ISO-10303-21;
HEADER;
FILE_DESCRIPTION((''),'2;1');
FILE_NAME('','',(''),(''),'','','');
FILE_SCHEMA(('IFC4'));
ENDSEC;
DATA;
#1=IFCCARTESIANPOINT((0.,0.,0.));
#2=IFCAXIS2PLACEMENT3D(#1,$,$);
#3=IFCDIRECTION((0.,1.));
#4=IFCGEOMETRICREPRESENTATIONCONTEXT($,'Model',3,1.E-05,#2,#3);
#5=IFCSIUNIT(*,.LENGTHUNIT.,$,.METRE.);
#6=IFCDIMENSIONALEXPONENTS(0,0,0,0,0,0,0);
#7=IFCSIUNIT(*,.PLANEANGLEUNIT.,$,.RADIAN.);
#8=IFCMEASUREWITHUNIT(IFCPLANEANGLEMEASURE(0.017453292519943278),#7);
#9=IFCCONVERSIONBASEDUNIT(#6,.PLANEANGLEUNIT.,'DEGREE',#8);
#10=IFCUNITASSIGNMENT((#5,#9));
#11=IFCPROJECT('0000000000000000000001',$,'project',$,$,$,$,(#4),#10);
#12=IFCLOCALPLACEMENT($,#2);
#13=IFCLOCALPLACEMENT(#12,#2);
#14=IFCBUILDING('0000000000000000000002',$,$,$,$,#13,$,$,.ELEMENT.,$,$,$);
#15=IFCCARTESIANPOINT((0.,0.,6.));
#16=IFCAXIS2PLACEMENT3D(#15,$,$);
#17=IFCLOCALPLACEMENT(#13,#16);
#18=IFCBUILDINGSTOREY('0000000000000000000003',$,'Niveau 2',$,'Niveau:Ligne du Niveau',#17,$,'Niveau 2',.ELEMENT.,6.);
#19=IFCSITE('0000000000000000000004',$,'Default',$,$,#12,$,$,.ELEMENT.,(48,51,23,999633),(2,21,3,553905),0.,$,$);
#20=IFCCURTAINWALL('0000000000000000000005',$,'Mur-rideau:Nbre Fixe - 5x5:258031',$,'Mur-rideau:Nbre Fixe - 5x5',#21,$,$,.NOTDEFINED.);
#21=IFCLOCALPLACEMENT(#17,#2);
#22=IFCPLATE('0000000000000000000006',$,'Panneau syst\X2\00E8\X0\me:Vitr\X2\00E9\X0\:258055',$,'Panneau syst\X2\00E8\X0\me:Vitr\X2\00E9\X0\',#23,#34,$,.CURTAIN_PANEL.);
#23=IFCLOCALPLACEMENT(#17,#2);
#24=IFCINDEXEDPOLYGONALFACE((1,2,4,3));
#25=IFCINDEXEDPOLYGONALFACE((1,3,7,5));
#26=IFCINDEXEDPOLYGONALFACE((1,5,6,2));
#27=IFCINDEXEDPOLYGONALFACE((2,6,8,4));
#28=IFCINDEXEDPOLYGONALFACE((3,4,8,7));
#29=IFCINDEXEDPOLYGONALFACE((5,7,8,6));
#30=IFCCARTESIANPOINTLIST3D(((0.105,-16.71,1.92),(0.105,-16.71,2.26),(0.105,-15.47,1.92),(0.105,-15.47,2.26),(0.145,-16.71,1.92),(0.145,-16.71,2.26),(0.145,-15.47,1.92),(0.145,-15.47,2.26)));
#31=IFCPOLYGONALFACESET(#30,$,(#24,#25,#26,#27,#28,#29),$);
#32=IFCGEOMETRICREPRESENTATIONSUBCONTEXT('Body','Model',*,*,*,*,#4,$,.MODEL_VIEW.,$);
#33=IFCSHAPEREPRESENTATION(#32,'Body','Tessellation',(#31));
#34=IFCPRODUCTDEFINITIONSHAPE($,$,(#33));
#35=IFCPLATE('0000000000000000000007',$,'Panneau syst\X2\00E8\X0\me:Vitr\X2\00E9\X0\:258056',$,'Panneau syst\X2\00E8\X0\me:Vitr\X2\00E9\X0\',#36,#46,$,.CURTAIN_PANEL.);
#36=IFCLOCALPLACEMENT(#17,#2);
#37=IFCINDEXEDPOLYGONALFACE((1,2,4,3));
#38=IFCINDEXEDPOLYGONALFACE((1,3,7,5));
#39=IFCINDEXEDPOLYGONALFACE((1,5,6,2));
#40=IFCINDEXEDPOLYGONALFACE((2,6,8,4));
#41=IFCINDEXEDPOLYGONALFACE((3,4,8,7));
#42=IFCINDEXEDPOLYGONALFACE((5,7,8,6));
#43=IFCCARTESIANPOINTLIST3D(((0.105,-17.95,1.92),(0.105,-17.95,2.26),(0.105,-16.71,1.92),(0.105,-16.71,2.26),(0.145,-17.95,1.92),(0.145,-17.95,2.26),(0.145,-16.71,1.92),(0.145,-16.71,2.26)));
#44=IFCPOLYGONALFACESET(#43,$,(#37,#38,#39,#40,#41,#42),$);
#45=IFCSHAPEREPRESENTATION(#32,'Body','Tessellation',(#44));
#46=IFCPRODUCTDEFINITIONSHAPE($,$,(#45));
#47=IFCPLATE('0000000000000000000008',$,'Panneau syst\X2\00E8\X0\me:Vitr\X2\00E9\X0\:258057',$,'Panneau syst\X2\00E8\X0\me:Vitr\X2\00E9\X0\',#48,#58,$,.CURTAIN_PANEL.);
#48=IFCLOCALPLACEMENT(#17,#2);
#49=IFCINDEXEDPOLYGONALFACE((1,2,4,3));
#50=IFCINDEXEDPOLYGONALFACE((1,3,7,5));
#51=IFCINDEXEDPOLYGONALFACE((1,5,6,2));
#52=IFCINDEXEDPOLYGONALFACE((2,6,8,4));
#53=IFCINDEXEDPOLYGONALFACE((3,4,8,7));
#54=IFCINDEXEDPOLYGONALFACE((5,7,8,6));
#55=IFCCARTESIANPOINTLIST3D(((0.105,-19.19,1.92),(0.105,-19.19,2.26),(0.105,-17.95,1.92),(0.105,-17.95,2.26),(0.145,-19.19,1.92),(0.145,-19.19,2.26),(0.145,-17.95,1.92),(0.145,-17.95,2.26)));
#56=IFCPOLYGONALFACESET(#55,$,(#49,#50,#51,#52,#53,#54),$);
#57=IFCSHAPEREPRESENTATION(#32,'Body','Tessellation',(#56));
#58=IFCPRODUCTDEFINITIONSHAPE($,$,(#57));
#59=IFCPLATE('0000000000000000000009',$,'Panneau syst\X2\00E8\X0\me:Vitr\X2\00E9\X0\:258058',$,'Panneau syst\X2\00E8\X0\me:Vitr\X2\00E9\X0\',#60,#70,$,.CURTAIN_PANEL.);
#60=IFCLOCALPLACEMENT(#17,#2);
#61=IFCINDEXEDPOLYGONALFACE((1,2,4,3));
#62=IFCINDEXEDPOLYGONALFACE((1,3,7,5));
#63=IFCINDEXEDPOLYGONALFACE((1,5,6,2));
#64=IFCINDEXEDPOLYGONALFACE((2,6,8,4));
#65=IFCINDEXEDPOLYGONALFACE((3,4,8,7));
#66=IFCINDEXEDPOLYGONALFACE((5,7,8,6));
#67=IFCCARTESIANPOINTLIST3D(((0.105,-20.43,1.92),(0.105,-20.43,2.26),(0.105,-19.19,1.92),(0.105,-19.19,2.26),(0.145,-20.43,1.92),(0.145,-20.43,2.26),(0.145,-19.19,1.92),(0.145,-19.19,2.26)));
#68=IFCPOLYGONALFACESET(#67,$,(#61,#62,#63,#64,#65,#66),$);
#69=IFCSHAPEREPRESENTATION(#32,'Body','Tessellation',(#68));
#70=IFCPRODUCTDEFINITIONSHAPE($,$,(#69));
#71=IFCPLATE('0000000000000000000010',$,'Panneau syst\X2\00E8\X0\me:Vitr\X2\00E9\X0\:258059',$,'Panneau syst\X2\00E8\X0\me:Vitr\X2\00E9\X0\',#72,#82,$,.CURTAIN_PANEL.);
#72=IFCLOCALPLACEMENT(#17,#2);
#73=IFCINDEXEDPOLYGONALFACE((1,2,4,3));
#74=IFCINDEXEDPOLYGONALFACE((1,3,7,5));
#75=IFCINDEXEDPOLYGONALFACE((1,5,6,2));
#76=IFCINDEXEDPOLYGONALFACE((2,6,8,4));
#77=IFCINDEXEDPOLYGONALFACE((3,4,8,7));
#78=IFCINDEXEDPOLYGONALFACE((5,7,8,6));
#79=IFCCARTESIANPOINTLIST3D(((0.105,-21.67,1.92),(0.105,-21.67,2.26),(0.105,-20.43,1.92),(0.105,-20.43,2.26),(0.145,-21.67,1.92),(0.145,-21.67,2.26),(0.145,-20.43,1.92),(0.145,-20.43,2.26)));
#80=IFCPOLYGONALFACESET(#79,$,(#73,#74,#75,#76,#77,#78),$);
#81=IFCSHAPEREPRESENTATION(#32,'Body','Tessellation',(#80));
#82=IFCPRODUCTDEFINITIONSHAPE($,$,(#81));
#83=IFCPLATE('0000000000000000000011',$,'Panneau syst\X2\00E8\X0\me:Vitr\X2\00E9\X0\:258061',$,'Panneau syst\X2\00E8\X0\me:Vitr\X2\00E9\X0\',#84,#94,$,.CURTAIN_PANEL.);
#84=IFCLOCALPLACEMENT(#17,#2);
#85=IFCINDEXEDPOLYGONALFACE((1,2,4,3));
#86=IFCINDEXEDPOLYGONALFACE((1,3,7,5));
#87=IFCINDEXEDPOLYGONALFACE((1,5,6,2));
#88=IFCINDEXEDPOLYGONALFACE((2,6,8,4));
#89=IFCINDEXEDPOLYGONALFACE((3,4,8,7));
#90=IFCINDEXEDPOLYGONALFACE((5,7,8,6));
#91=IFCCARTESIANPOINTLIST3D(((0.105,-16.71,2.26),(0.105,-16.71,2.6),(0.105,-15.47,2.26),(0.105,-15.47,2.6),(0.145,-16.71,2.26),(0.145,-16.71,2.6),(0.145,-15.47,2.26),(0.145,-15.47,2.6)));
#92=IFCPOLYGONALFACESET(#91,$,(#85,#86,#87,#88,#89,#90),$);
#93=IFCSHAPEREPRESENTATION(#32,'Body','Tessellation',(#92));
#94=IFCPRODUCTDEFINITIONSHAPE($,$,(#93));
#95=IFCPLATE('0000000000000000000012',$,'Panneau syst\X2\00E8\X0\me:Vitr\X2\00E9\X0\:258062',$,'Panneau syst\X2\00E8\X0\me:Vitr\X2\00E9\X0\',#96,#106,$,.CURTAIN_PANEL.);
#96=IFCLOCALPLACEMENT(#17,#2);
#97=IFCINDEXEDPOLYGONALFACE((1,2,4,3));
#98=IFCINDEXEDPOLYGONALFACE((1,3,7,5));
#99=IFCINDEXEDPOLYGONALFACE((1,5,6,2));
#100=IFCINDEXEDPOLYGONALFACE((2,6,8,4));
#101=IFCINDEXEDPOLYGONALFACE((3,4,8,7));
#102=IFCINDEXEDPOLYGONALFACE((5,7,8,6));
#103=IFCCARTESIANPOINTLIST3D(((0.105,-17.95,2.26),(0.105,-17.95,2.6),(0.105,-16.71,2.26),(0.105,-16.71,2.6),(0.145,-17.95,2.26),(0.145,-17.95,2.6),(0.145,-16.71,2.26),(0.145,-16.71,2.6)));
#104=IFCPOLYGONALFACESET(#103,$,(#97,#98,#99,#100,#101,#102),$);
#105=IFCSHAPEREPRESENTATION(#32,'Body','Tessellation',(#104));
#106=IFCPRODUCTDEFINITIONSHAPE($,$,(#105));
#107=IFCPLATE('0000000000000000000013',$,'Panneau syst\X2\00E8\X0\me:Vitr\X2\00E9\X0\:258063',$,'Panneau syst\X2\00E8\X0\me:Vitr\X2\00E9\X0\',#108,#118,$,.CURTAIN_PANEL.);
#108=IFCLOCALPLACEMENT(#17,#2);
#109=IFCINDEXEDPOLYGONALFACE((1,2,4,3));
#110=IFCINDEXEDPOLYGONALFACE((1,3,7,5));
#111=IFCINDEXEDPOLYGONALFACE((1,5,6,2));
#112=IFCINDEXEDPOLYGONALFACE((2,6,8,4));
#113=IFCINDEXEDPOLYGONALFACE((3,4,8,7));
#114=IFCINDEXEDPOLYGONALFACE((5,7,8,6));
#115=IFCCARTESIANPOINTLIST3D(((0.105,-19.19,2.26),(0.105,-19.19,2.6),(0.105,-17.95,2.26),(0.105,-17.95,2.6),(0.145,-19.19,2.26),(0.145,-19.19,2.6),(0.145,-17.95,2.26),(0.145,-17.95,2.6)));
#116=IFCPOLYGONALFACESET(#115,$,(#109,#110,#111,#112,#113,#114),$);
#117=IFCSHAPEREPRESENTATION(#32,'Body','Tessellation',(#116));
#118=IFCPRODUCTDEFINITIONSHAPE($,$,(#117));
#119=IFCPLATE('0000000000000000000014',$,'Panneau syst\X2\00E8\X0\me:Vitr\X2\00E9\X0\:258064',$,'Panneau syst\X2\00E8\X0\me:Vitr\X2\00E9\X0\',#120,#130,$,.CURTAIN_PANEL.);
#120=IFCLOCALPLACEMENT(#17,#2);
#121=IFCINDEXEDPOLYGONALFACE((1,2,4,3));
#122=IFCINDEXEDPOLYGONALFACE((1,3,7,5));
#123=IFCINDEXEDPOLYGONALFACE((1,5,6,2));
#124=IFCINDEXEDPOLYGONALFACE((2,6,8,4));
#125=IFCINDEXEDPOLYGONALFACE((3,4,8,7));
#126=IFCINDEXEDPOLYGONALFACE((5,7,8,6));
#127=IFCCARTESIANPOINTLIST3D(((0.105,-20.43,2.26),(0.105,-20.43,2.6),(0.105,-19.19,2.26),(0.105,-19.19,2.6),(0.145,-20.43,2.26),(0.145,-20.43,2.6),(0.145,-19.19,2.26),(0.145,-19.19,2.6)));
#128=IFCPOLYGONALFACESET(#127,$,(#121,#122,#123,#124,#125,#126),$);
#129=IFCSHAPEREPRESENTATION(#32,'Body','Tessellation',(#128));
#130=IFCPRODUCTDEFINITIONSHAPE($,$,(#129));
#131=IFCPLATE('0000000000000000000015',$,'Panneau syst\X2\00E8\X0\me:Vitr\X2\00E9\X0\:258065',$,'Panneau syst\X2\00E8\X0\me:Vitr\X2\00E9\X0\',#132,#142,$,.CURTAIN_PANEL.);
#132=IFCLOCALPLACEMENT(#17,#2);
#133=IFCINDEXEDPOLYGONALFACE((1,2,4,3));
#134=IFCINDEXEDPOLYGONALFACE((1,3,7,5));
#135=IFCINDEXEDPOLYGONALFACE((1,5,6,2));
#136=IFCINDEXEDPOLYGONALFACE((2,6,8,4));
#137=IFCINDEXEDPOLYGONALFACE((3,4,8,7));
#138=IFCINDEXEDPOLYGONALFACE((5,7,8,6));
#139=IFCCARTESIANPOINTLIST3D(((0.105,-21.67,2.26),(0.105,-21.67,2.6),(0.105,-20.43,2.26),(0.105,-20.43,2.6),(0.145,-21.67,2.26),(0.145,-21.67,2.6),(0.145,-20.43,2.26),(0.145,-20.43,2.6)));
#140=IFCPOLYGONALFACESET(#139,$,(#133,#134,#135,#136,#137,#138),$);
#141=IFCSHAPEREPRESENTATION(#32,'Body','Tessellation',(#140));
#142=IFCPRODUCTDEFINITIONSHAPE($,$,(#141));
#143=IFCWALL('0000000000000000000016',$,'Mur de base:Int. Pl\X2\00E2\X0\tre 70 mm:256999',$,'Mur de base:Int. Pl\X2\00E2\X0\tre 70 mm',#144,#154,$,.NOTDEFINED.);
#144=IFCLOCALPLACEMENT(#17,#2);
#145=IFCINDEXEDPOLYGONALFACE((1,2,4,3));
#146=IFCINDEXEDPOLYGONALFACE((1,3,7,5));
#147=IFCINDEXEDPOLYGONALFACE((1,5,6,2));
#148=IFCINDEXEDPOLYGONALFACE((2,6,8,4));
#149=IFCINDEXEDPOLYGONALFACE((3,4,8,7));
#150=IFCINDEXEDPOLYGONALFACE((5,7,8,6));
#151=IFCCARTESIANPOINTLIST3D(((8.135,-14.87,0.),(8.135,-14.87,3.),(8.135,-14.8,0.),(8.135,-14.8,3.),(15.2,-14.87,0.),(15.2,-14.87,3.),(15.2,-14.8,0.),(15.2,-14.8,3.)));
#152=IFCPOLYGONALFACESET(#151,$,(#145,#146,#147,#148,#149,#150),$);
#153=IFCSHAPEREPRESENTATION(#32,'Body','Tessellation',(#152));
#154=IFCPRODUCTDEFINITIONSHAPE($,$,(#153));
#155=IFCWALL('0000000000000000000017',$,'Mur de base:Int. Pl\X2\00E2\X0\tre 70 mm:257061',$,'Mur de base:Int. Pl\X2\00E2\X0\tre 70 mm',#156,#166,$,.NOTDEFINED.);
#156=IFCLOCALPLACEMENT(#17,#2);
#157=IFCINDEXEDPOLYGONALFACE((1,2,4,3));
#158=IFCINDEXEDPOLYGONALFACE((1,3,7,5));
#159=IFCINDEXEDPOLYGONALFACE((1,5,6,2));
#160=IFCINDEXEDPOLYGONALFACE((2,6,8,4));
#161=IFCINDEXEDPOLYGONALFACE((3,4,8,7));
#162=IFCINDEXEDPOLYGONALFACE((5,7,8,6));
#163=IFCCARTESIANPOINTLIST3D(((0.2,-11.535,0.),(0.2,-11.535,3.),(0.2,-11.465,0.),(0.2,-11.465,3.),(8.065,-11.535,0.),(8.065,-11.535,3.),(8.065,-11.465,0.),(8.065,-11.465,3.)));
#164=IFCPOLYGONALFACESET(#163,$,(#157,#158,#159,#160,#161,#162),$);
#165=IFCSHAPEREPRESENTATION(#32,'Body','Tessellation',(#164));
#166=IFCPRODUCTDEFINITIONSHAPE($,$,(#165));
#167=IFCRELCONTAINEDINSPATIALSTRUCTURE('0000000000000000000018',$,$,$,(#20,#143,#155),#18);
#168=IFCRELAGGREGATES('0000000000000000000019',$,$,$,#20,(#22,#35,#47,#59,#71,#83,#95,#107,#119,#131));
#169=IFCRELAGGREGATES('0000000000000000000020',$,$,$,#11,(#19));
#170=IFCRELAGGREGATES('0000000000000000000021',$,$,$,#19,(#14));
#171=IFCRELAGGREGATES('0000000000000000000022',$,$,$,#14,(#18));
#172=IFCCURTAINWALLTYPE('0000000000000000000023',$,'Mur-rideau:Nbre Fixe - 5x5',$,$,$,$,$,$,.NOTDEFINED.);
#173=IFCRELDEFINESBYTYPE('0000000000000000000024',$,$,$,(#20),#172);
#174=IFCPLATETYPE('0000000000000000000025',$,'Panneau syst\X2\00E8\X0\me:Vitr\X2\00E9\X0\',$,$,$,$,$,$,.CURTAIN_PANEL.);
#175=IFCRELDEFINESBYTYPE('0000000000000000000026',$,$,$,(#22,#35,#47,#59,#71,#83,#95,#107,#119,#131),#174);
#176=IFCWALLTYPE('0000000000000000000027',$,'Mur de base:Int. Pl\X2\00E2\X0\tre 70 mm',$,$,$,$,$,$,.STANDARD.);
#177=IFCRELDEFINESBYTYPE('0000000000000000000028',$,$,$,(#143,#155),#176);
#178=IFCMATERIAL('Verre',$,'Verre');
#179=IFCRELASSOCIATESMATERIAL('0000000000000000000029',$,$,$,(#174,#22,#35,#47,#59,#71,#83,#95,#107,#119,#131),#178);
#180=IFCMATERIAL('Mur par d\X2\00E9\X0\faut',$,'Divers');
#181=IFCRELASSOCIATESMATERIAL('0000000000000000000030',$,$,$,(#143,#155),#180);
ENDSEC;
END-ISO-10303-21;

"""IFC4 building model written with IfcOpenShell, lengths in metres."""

from ifc_helpers import new_model, entity, si_unit, converted_unit, direction, frame, origin, place, context, subcontext, project, spatial, indexed_curve, outline, extrude, source, transform, mapped, material, type_object, type_shapes, element, aggregate, save


model = new_model("IFC4")

# Units and contexts
model_context = context("Model", 3, precision=1e-05, world=origin(), true_north=direction((0.0, 1.0)))
body_context = subcontext(model_context, "Body", "Model", "MODEL_VIEW")
ifc_project = project(units=[si_unit("LENGTHUNIT", "METRE"), converted_unit("PLANEANGLEUNIT", "DEGREE", entity("IfcPlaneAngleMeasure", 0.017453292519943278), si_unit("PLANEANGLEUNIT", "RADIAN"), dimensions=[0, 0, 0, 0, 0, 0, 0])], contexts=[model_context])

# Site, building, storey
site_placement = place(None, origin())
site = spatial("IfcSite", under=ifc_project, at=site_placement, Name="Default", CompositionType="ELEMENT", RefLatitude=(48, 51, 23, 999633), RefLongitude=(2, 21, 3, 553905), RefElevation=0.0)
building_placement = place(site_placement, origin())
building = spatial("IfcBuilding", under=site, at=building_placement, CompositionType="ELEMENT")
storey_placement = place(building_placement, frame((0.0, 0.0, 6.0)))
storey = spatial("IfcBuildingStorey", under=building, at=storey_placement, Name="Niveau 2", ObjectType="Niveau:Ligne du Niveau", LongName="Niveau 2", CompositionType="ELEMENT", Elevation=6.0)

# Curtain wall, plates
curtain_wall_type = type_object("IfcCurtainWallType", Name="Mur-rideau:Nbre Fixe - 5x5", PredefinedType="NOTDEFINED")
curtain_wall_placement = place(storey_placement, frame((0.0, 0.0, -6.0)))
curtain_wall = element("IfcCurtainWall", 1, at=curtain_wall_placement, inside=storey, type_object=curtain_wall_type, Name="Mur-rideau:Nbre Fixe - 5x5:258031", ObjectType="Mur-rideau:Nbre Fixe - 5x5", PredefinedType="NOTDEFINED")
ifc_material_1 = material(Name="Verre", Category="Verre")
plate_type = type_object("IfcPlateType", Name="Panneau système:Vitré", PredefinedType="CURTAIN_PANEL", material=ifc_material_1)
shared_shape = source(origin(), body_context, "Body", "SweptSolid", [
    extrude(outline(indexed_curve([(-0.02, -0.62), (0.02, -0.62), (0.02, 0.62), (-0.02, 0.62), (-0.02, -0.62)], self_intersect=False)), frame((0.62, 0.02, 0.0), z_axis=(0.0, 0.0, 1.0), x_axis=(0.0, 1.0, 0.0)), (0.0, 0.0, 1.0), 0.34),
])
type_shapes(plate_type, [shared_shape])
plate_1_placement = place(curtain_wall_placement, frame((0.105, -15.47, 7.92), z_axis=(0.0, 0.0, 1.0), x_axis=(0.0, -1.0, 0.0)))
plate_1 = element("IfcPlate", 2, at=plate_1_placement, type_object=plate_type, material=ifc_material_1, Name="Panneau système:Vitré:258055", ObjectType="Panneau système:Vitré", PredefinedType="CURTAIN_PANEL", context=body_context, shape_type="MappedRepresentation", body=[
    mapped(shared_shape, transform((0.0, 0.0, 0.0), scale=1.0)),
])
plate_2_placement = place(curtain_wall_placement, frame((0.105, -16.71, 7.92), z_axis=(0.0, 0.0, 1.0), x_axis=(0.0, -1.0, 0.0)))
plate_2 = element("IfcPlate", 3, at=plate_2_placement, type_object=plate_type, material=ifc_material_1, Name="Panneau système:Vitré:258056", ObjectType="Panneau système:Vitré", PredefinedType="CURTAIN_PANEL", context=body_context, shape_type="MappedRepresentation", body=[
    mapped(shared_shape, transform((0.0, 0.0, 0.0), scale=1.0)),
])
plate_3_placement = place(curtain_wall_placement, frame((0.105, -17.95, 7.92), z_axis=(0.0, 0.0, 1.0), x_axis=(0.0, -1.0, 0.0)))
plate_3 = element("IfcPlate", 4, at=plate_3_placement, type_object=plate_type, material=ifc_material_1, Name="Panneau système:Vitré:258057", ObjectType="Panneau système:Vitré", PredefinedType="CURTAIN_PANEL", context=body_context, shape_type="MappedRepresentation", body=[
    mapped(shared_shape, transform((0.0, 0.0, 0.0), scale=1.0)),
])
plate_4_placement = place(curtain_wall_placement, frame((0.105, -19.19, 7.92), z_axis=(0.0, 0.0, 1.0), x_axis=(0.0, -1.0, 0.0)))
plate_4 = element("IfcPlate", 5, at=plate_4_placement, type_object=plate_type, material=ifc_material_1, Name="Panneau système:Vitré:258058", ObjectType="Panneau système:Vitré", PredefinedType="CURTAIN_PANEL", context=body_context, shape_type="MappedRepresentation", body=[
    mapped(shared_shape, transform((0.0, 0.0, 0.0), scale=1.0)),
])
plate_5_placement = place(curtain_wall_placement, frame((0.105, -20.43, 7.92), z_axis=(0.0, 0.0, 1.0), x_axis=(0.0, -1.0, 0.0)))
plate_5 = element("IfcPlate", 6, at=plate_5_placement, type_object=plate_type, material=ifc_material_1, Name="Panneau système:Vitré:258059", ObjectType="Panneau système:Vitré", PredefinedType="CURTAIN_PANEL", context=body_context, shape_type="MappedRepresentation", body=[
    mapped(shared_shape, transform((0.0, 0.0, 0.0), scale=1.0)),
])
plate_6_placement = place(curtain_wall_placement, frame((0.105, -15.47, 8.26), z_axis=(0.0, 0.0, 1.0), x_axis=(0.0, -1.0, 0.0)))
plate_6 = element("IfcPlate", 7, at=plate_6_placement, type_object=plate_type, material=ifc_material_1, Name="Panneau système:Vitré:258061", ObjectType="Panneau système:Vitré", PredefinedType="CURTAIN_PANEL", context=body_context, shape_type="MappedRepresentation", body=[
    mapped(shared_shape, transform((0.0, 0.0, 0.0), scale=1.0)),
])
plate_7_placement = place(curtain_wall_placement, frame((0.105, -16.71, 8.26), z_axis=(0.0, 0.0, 1.0), x_axis=(0.0, -1.0, 0.0)))
plate_7 = element("IfcPlate", 8, at=plate_7_placement, type_object=plate_type, material=ifc_material_1, Name="Panneau système:Vitré:258062", ObjectType="Panneau système:Vitré", PredefinedType="CURTAIN_PANEL", context=body_context, shape_type="MappedRepresentation", body=[
    mapped(shared_shape, transform((0.0, 0.0, 0.0), scale=1.0)),
])
plate_8_placement = place(curtain_wall_placement, frame((0.105, -17.95, 8.26), z_axis=(0.0, 0.0, 1.0), x_axis=(0.0, -1.0, 0.0)))
plate_8 = element("IfcPlate", 9, at=plate_8_placement, type_object=plate_type, material=ifc_material_1, Name="Panneau système:Vitré:258063", ObjectType="Panneau système:Vitré", PredefinedType="CURTAIN_PANEL", context=body_context, shape_type="MappedRepresentation", body=[
    mapped(shared_shape, transform((0.0, 0.0, 0.0), scale=1.0)),
])
plate_9_placement = place(curtain_wall_placement, frame((0.105, -19.19, 8.26), z_axis=(0.0, 0.0, 1.0), x_axis=(0.0, -1.0, 0.0)))
plate_9 = element("IfcPlate", 10, at=plate_9_placement, type_object=plate_type, material=ifc_material_1, Name="Panneau système:Vitré:258064", ObjectType="Panneau système:Vitré", PredefinedType="CURTAIN_PANEL", context=body_context, shape_type="MappedRepresentation", body=[
    mapped(shared_shape, transform((0.0, 0.0, 0.0), scale=1.0)),
])
plate_10_placement = place(curtain_wall_placement, frame((0.105, -20.43, 8.26), z_axis=(0.0, 0.0, 1.0), x_axis=(0.0, -1.0, 0.0)))
plate_10 = element("IfcPlate", 11, at=plate_10_placement, type_object=plate_type, material=ifc_material_1, Name="Panneau système:Vitré:258065", ObjectType="Panneau système:Vitré", PredefinedType="CURTAIN_PANEL", context=body_context, shape_type="MappedRepresentation", body=[
    mapped(shared_shape, transform((0.0, 0.0, 0.0), scale=1.0)),
])
aggregate(curtain_wall, [plate_1, plate_2, plate_3, plate_4, plate_5, plate_6, plate_7, plate_8, plate_9, plate_10])

# Walls
ifc_material_2 = material(Name="Mur par défaut", Category="Divers")
wall_type = type_object("IfcWallType", Name="Mur de base:Int. Plâtre 70 mm", PredefinedType="STANDARD")
wall_1_placement = place(storey_placement, frame((8.135, -14.835, 0.0)))
element("IfcWall", 12, at=wall_1_placement, inside=storey, type_object=wall_type, material=ifc_material_2, Name="Mur de base:Int. Plâtre 70 mm:256999", ObjectType="Mur de base:Int. Plâtre 70 mm", PredefinedType="NOTDEFINED", context=body_context, shape_type="SweptSolid", body=[
    extrude(outline(indexed_curve([(7.065, 0.035), (0.0, 0.035), (0.0, -0.035), (7.065, -0.035), (7.065, 0.035)], self_intersect=False)), origin(), (0.0, 0.0, 1.0), 3.0),
])
wall_2_placement = place(storey_placement, frame((8.065, -11.5, 0.0), z_axis=(0.0, 0.0, 1.0), x_axis=(-1.0, 0.0, 0.0)))
element("IfcWall", 13, at=wall_2_placement, inside=storey, type_object=wall_type, material=ifc_material_2, Name="Mur de base:Int. Plâtre 70 mm:257061", ObjectType="Mur de base:Int. Plâtre 70 mm", PredefinedType="NOTDEFINED", context=body_context, shape_type="SweptSolid", body=[
    extrude(outline(indexed_curve([(7.865, 0.035), (0.0, 0.035), (0.0, -0.035), (7.865, -0.035), (7.865, 0.035)], self_intersect=False)), origin(), (0.0, 0.0, 1.0), 3.0),
])

save(model, "model.ifc")
